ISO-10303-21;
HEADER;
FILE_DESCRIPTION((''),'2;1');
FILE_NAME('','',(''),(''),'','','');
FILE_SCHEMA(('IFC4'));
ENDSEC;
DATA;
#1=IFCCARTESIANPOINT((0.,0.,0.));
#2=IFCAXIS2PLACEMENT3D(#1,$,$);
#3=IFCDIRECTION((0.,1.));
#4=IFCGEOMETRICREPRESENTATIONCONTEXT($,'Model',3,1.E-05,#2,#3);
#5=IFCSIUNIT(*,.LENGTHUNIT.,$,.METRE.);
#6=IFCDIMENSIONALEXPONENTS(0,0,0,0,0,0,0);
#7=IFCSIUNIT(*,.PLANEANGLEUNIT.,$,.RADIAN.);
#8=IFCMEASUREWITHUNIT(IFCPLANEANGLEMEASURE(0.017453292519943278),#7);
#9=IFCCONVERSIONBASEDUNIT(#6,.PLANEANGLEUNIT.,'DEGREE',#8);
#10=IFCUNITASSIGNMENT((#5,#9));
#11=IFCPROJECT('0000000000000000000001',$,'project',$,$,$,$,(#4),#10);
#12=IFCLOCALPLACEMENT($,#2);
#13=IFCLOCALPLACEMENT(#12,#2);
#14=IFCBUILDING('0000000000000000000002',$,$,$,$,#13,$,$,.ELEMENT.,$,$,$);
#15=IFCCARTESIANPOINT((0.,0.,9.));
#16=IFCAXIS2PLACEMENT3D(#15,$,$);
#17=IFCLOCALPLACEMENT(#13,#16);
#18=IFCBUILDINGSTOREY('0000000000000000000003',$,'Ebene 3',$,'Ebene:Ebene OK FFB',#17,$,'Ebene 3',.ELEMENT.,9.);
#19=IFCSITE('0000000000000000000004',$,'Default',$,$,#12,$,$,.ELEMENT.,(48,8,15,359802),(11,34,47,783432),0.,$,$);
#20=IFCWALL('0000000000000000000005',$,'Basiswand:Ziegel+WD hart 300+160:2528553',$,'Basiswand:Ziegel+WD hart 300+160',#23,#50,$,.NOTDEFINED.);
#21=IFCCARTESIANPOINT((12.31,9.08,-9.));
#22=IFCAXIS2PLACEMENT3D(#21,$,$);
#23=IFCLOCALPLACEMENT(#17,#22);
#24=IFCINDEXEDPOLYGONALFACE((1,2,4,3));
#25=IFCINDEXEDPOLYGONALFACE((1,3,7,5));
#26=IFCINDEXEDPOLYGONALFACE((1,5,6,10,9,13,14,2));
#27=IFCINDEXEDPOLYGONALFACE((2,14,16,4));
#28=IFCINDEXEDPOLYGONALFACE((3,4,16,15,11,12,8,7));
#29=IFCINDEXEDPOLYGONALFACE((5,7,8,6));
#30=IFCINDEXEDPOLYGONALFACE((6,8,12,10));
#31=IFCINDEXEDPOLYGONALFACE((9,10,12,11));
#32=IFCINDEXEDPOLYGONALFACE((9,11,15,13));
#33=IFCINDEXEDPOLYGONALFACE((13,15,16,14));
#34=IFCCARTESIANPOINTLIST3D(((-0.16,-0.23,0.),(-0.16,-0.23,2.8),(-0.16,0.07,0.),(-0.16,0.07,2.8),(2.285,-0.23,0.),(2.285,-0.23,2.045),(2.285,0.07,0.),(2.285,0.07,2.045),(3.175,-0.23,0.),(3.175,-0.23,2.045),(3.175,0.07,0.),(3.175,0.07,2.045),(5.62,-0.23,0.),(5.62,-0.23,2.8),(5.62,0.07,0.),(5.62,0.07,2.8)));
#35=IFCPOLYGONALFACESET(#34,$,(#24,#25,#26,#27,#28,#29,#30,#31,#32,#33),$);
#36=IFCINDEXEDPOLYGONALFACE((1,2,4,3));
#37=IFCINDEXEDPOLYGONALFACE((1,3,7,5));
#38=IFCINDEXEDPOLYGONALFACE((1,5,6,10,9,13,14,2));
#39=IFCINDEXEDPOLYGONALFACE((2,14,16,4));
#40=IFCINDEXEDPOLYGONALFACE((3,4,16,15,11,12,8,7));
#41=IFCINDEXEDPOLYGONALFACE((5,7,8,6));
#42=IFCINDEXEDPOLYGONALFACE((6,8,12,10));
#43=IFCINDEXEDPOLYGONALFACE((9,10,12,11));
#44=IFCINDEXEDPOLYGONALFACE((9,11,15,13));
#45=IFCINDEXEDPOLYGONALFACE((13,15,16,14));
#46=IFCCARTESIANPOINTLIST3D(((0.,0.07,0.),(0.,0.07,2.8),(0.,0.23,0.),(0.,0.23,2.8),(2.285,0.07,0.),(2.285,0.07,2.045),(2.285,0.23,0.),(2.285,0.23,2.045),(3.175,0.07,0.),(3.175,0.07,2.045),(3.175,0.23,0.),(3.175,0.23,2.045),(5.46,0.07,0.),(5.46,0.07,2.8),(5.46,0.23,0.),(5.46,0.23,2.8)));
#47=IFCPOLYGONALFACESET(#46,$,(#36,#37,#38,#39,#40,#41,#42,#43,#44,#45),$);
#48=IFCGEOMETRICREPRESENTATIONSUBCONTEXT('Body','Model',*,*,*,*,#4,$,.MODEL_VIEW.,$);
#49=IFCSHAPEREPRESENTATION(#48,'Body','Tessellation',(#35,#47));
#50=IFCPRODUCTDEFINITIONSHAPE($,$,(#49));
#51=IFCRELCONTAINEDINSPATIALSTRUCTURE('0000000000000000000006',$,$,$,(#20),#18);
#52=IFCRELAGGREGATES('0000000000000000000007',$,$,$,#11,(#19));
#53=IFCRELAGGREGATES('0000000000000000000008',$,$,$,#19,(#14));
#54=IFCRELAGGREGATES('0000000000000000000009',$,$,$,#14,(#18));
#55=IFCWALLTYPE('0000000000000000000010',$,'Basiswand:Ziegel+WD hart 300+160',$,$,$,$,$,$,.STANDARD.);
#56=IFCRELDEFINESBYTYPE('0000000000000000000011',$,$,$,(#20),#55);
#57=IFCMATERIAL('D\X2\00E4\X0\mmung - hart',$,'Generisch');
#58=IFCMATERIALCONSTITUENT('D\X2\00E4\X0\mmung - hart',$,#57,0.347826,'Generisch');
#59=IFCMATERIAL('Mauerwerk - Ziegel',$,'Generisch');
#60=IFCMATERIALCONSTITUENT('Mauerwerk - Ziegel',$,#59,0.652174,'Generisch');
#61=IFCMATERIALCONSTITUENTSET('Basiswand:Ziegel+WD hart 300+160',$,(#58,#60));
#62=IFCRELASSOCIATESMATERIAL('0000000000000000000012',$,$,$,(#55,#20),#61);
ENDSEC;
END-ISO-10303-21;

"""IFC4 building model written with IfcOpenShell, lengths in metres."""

from ifc_helpers import new_model, entity, si_unit, converted_unit, direction, frame, origin, place, context, subcontext, project, spatial, indexed_curve, outline, extrude, material, constituent, constituent_set, type_object, element, save


model = new_model("IFC4")

# Units and contexts
model_context = context("Model", 3, precision=1e-05, world=origin(), true_north=direction((0.0, 1.0)))
body_context = subcontext(model_context, "Body", "Model", "MODEL_VIEW")
ifc_project = project(units=[si_unit("LENGTHUNIT", "METRE"), converted_unit("PLANEANGLEUNIT", "DEGREE", entity("IfcPlaneAngleMeasure", 0.017453292519943278), si_unit("PLANEANGLEUNIT", "RADIAN"), dimensions=[0, 0, 0, 0, 0, 0, 0])], contexts=[model_context])

# Site, building, storey
site_placement = place(None, origin())
site = spatial("IfcSite", under=ifc_project, at=site_placement, Name="Default", CompositionType="ELEMENT", RefLatitude=(48, 8, 15, 359802), RefLongitude=(11, 34, 47, 783432), RefElevation=0.0)
building_placement = place(site_placement, origin())
building = spatial("IfcBuilding", under=site, at=building_placement, CompositionType="ELEMENT")
storey_placement = place(building_placement, frame((0.0, 0.0, 9.0)))
storey = spatial("IfcBuildingStorey", under=building, at=storey_placement, Name="Ebene 3", ObjectType="Ebene:Ebene OK FFB", LongName="Ebene 3", CompositionType="ELEMENT", Elevation=9.0)

# Shared definitions
ifc_material_1 = material(Name="Dämmung - hart", Category="Generisch")
ifc_constituent_1 = constituent(ifc_material_1, Name="Dämmung - hart", Category="Generisch", fraction=0.347826)
ifc_material_2 = material(Name="Mauerwerk - Ziegel", Category="Generisch")
ifc_constituent_2 = constituent(ifc_material_2, Name="Mauerwerk - Ziegel", Category="Generisch", fraction=0.652174)
ifc_constituent_set_1 = constituent_set(constituents=[ifc_constituent_1, ifc_constituent_2], Name="Basiswand:Ziegel+WD hart 300+160")
wall_type = type_object("IfcWallType", Name="Basiswand:Ziegel+WD hart 300+160", PredefinedType="STANDARD", material=ifc_constituent_set_1)

# Wall, opening
wall_1_placement = place(storey_placement, frame((12.31, 9.08, -9.0)))
wall_1 = element("IfcWall", 1, at=wall_1_placement, inside=storey, type_object=wall_type, material=ifc_constituent_set_1, Name="Basiswand:Ziegel+WD hart 300+160:2528553", ObjectType="Basiswand:Ziegel+WD hart 300+160", PredefinedType="NOTDEFINED", context=body_context, shape_type="SweptSolid", body=[
    extrude(outline(indexed_curve([(-2.89, -1.5888), (2.89, -1.5888), (2.89, 1.2112), (0.445, 1.2112), (0.445, -0.8337), (-0.445, -0.8337), (-0.445, 1.2112), (-2.89, 1.2112), (-2.89, -1.5888)], self_intersect=False)), frame((2.73, -0.23, 1.2112), z_axis=(0.0, 1.0, 0.0), x_axis=(1.0, 0.0, 0.0)), (0.0, 0.0, 1.0), 0.3),
    extrude(outline(indexed_curve([(-1.2112, -0.445), (-1.2112, -2.73), (1.5888, -2.73), (1.5888, 2.73), (-1.2112, 2.73), (-1.2112, 0.445), (0.8337, 0.445), (0.8337, -0.445), (-1.2112, -0.445)], self_intersect=False)), frame((2.73, 0.07, 1.2112), z_axis=(0.0, -1.0, 0.0), x_axis=(0.0, 0.0, 1.0)), (0.0, 0.0, -1.0), 0.16),
])
opening_1_placement = place(wall_1_placement, frame((3.175, 0.23, -0.18)))
element("IfcOpeningElement", 2, at=opening_1_placement, cuts=wall_1, PredefinedType="OPENING", context=body_context, shape_type="SweptSolid", body=[
    extrude(outline(indexed_curve([(2.225, 0.89), (0.0, 0.89), (0.0, 0.0), (2.225, 0.0), (2.225, 0.89)], self_intersect=False)), frame((0.0, 0.0, 0.0), z_axis=(0.0, -1.0, 0.0), x_axis=(0.0, 0.0, 1.0)), (0.0, 0.0, 1.0), 0.46),
])

save(model, "model.ifc")
